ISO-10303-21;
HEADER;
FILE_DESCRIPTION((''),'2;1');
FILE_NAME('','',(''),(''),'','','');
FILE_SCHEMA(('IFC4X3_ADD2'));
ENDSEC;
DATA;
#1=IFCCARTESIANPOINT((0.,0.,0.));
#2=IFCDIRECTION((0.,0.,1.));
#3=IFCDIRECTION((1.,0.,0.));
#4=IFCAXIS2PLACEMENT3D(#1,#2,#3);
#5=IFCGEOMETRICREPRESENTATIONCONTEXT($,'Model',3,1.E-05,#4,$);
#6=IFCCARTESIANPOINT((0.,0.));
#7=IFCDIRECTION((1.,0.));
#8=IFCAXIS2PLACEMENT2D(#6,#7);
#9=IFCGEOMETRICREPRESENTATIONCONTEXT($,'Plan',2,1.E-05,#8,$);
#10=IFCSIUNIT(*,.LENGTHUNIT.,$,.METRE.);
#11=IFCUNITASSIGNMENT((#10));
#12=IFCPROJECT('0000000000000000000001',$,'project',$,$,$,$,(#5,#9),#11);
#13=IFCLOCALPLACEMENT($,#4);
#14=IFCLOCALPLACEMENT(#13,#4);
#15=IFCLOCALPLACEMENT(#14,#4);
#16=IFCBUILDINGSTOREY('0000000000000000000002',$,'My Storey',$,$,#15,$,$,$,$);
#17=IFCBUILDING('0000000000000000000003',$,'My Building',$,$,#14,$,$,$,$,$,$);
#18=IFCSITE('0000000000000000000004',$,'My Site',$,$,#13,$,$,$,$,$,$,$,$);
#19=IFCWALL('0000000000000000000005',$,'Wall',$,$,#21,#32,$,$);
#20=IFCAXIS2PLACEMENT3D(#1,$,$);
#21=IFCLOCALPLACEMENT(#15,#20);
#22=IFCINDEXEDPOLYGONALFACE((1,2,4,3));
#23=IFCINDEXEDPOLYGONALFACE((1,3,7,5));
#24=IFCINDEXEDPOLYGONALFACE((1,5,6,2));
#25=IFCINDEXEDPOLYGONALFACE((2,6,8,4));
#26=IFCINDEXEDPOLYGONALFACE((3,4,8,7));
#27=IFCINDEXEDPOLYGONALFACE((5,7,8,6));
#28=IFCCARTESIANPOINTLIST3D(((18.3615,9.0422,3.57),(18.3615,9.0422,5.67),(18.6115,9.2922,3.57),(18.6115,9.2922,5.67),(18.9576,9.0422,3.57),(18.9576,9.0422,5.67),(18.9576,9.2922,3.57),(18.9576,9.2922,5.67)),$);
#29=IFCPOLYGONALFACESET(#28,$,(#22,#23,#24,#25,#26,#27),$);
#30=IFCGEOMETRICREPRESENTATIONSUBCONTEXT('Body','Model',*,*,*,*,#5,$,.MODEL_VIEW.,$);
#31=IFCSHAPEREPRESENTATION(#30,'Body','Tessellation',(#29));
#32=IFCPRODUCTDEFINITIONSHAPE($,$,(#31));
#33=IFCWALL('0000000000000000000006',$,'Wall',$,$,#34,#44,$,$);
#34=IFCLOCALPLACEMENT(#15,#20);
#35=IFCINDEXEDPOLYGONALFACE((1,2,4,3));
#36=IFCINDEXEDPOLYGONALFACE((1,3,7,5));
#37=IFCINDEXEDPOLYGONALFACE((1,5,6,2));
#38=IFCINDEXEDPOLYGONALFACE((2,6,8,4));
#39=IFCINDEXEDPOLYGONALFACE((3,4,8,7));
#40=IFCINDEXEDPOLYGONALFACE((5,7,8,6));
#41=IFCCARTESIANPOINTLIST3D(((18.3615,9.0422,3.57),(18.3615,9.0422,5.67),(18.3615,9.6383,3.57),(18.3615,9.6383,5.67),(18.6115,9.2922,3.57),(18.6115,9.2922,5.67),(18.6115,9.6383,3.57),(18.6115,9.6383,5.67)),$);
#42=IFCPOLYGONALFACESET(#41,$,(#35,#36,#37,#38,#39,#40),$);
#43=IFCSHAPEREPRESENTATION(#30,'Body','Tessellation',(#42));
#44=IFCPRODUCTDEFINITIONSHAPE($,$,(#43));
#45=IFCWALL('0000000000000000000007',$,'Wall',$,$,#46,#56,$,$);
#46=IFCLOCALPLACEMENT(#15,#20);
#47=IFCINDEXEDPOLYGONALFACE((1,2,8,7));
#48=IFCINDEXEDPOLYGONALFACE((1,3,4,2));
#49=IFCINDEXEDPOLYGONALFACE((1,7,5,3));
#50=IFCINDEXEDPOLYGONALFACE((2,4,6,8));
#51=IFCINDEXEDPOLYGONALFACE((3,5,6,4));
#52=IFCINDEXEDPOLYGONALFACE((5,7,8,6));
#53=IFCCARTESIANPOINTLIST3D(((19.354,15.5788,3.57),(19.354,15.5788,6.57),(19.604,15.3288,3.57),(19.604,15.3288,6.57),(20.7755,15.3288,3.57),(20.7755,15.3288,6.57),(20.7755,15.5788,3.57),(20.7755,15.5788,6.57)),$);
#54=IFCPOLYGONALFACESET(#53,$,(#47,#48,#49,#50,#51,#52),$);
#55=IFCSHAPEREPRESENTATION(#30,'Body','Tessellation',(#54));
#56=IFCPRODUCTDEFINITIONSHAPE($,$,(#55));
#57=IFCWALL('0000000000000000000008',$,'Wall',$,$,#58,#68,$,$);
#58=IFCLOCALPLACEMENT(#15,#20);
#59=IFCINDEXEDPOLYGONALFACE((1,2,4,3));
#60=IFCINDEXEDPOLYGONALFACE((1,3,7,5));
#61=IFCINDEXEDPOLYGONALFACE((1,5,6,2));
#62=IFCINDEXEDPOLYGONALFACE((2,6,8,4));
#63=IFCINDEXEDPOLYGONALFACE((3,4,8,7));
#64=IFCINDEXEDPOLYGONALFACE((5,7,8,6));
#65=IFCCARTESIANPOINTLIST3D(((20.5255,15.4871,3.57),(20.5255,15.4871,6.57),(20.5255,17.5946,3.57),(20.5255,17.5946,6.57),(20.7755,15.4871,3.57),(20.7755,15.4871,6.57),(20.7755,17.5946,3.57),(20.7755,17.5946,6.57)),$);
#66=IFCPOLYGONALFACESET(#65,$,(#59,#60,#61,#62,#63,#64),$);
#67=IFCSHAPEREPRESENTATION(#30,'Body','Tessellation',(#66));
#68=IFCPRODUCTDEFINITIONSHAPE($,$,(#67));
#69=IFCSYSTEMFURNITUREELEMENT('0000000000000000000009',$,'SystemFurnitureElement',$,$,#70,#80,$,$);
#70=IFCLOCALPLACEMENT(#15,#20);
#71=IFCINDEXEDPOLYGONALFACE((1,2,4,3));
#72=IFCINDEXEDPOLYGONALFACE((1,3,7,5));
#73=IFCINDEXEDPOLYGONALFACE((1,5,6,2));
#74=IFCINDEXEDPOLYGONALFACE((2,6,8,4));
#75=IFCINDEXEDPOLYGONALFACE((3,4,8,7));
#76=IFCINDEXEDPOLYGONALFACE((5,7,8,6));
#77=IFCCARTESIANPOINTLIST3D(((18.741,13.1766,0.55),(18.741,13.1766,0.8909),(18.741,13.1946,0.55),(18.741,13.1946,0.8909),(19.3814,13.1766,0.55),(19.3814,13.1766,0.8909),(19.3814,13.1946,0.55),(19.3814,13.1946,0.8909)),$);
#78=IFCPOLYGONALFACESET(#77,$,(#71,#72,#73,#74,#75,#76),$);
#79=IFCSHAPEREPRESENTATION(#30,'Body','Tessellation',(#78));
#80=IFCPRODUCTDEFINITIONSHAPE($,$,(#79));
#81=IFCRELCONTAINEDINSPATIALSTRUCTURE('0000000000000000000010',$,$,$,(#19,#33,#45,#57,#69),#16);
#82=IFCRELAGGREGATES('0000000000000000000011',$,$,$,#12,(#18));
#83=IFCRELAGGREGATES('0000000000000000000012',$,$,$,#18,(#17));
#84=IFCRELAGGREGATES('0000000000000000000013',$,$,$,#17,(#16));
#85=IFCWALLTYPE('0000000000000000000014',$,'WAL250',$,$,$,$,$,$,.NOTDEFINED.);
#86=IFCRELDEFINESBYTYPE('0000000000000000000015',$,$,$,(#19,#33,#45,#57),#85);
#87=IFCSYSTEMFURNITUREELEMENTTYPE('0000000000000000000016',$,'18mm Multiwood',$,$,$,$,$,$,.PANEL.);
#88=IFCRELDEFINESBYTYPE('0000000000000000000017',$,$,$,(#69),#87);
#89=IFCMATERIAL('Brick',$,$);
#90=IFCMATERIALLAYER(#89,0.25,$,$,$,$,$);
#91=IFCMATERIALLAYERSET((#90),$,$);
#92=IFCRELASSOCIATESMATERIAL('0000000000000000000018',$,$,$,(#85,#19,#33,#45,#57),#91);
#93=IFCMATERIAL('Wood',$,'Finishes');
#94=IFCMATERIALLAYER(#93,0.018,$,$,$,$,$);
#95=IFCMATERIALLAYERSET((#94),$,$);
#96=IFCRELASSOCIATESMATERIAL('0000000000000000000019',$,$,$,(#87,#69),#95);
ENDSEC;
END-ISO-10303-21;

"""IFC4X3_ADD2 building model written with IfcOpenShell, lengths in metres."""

from ifc_helpers import new_model, si_unit, frame, origin_with_axes, origin_2d_with_axis, place, context, subcontext, project, spatial, line, indexed_curve, outline, extrude, material, layer, layer_set, layer_usage, type_object, element, save


model = new_model("IFC4X3_ADD2")

# Units and contexts
model_context = context("Model", 3, precision=1e-05, world=origin_with_axes())
plan_context = context("Plan", 2, precision=1e-05, world=origin_2d_with_axis())
body_context = subcontext(model_context, "Body", "Model", "MODEL_VIEW")
ifc_project = project(units=[si_unit("LENGTHUNIT", "METRE")], contexts=[model_context, plan_context])

# Site, building, storey
site_placement = place(None, origin_with_axes())
site = spatial("IfcSite", under=ifc_project, at=site_placement, Name="My Site")
building_placement = place(site_placement, origin_with_axes())
building = spatial("IfcBuilding", under=site, at=building_placement, Name="My Building")
storey_placement = place(building_placement, origin_with_axes())
storey = spatial("IfcBuildingStorey", under=building, at=storey_placement, Name="My Storey")

# Shared definitions
ifc_material_1 = material(Name="Brick")
ifc_layer_1 = layer(ifc_material_1, 0.25)
ifc_layer_set_1 = layer_set([ifc_layer_1])
wall_type = type_object("IfcWallType", Name="WAL250", PredefinedType="NOTDEFINED", material=ifc_layer_set_1)

# Walls
ifc_layer_usage_1 = layer_usage(ifc_layer_set_1, "AXIS2", "POSITIVE", 0.0)
wall_1_placement = place(storey_placement, frame((18.3615, 9.0422, 3.57), z_axis=(0.0, 0.0, 1.0), x_axis=(1.0, 0.000005, 0.0)))
element("IfcWall", 1, at=wall_1_placement, inside=storey, type_object=wall_type, material=ifc_layer_usage_1, Name="Wall", context=body_context, shape_type="SweptSolid", body=[
    extrude(outline(indexed_curve([(0.0, 0.0), (0.25, 0.25), (0.5961, 0.25), (0.5961, 0.0)], segments=[line(1, 2, 3, 4, 1)])), origin_with_axes(), (0.0, 0.0, 1.0), 2.1),
])
ifc_layer_usage_2 = layer_usage(ifc_layer_set_1, "AXIS2", "NEGATIVE", 0.0)
wall_2_placement = place(storey_placement, frame((18.3615, 9.0422, 3.57), z_axis=(0.0, 0.0, 1.0), x_axis=(-0.000005, 1.0, 0.0)))
element("IfcWall", 2, at=wall_2_placement, inside=storey, type_object=wall_type, material=ifc_layer_usage_2, Name="Wall", context=body_context, shape_type="SweptSolid", body=[
    extrude(outline(indexed_curve([(0.25, -0.25), (0.0, 0.0), (0.5961, 0.0), (0.5961, -0.25)], segments=[line(1, 2, 3, 4, 1)])), origin_with_axes(), (0.0, 0.0, 1.0), 2.1),
])
ifc_layer_usage_3 = layer_usage(ifc_layer_set_1, "AXIS2", "POSITIVE", 0.0)
wall_3_placement = place(storey_placement, frame((19.604, 15.3288, 3.57), z_axis=(0.0, 0.0, 1.0), x_axis=(1.0, 0.000006, 0.0)))
element("IfcWall", 3, at=wall_3_placement, inside=storey, type_object=wall_type, material=ifc_layer_usage_3, Name="Wall", context=body_context, shape_type="SweptSolid", body=[
    extrude(outline(indexed_curve([(0.0, 0.0), (-0.25, 0.25), (1.1716, 0.25), (1.1716, 0.0)], segments=[line(1, 2, 3, 4, 1)])), origin_with_axes(), (0.0, 0.0, 1.0), 3.0),
])
ifc_layer_usage_4 = layer_usage(ifc_layer_set_1, "AXIS2", "POSITIVE", 0.0)
wall_4_placement = place(storey_placement, frame((20.7755, 15.4871, 3.57), z_axis=(0.0, 0.0, 1.0), x_axis=(-0.000006, 1.0, 0.0)))
element("IfcWall", 4, at=wall_4_placement, inside=storey, type_object=wall_type, material=ifc_layer_usage_4, Name="Wall", context=body_context, shape_type="SweptSolid", body=[
    extrude(outline(indexed_curve([(0.0, 0.0), (0.0, 0.25), (2.1074, 0.25), (2.1074, 0.0)], segments=[line(1, 2, 3, 4, 1)])), origin_with_axes(), (0.0, 0.0, 1.0), 3.0),
])

# System furniture element
ifc_material_2 = material(Name="Wood", Category="Finishes")
ifc_layer_2 = layer(ifc_material_2, 0.018)
ifc_layer_set_2 = layer_set([ifc_layer_2])
ifc_layer_usage_5 = layer_usage(ifc_layer_set_2, "AXIS2", "POSITIVE", 0.0)
system_furniture_element_type_1 = type_object("IfcSystemFurnitureElementType", Name="18mm Multiwood", PredefinedType="PANEL", material=ifc_layer_set_2)
system_furniture_element_1_placement = place(storey_placement, frame((19.3814, 13.1946, 0.55), z_axis=(0.0, 0.0, 1.0), x_axis=(-1.0, 0.000001, 0.0)))
element("IfcSystemFurnitureElement", 5, at=system_furniture_element_1_placement, inside=storey, type_object=system_furniture_element_type_1, material=ifc_layer_usage_5, Name="SystemFurnitureElement", context=body_context, shape_type="SweptSolid", body=[
    extrude(outline(indexed_curve([(0.0, 0.0), (0.0, 0.018), (0.6404, 0.018), (0.6404, 0.0)], segments=[line(1, 2, 3, 4, 1)])), origin_with_axes(), (0.0, 0.0, 1.0), 0.3409),
])

save(model, "model.ifc")
